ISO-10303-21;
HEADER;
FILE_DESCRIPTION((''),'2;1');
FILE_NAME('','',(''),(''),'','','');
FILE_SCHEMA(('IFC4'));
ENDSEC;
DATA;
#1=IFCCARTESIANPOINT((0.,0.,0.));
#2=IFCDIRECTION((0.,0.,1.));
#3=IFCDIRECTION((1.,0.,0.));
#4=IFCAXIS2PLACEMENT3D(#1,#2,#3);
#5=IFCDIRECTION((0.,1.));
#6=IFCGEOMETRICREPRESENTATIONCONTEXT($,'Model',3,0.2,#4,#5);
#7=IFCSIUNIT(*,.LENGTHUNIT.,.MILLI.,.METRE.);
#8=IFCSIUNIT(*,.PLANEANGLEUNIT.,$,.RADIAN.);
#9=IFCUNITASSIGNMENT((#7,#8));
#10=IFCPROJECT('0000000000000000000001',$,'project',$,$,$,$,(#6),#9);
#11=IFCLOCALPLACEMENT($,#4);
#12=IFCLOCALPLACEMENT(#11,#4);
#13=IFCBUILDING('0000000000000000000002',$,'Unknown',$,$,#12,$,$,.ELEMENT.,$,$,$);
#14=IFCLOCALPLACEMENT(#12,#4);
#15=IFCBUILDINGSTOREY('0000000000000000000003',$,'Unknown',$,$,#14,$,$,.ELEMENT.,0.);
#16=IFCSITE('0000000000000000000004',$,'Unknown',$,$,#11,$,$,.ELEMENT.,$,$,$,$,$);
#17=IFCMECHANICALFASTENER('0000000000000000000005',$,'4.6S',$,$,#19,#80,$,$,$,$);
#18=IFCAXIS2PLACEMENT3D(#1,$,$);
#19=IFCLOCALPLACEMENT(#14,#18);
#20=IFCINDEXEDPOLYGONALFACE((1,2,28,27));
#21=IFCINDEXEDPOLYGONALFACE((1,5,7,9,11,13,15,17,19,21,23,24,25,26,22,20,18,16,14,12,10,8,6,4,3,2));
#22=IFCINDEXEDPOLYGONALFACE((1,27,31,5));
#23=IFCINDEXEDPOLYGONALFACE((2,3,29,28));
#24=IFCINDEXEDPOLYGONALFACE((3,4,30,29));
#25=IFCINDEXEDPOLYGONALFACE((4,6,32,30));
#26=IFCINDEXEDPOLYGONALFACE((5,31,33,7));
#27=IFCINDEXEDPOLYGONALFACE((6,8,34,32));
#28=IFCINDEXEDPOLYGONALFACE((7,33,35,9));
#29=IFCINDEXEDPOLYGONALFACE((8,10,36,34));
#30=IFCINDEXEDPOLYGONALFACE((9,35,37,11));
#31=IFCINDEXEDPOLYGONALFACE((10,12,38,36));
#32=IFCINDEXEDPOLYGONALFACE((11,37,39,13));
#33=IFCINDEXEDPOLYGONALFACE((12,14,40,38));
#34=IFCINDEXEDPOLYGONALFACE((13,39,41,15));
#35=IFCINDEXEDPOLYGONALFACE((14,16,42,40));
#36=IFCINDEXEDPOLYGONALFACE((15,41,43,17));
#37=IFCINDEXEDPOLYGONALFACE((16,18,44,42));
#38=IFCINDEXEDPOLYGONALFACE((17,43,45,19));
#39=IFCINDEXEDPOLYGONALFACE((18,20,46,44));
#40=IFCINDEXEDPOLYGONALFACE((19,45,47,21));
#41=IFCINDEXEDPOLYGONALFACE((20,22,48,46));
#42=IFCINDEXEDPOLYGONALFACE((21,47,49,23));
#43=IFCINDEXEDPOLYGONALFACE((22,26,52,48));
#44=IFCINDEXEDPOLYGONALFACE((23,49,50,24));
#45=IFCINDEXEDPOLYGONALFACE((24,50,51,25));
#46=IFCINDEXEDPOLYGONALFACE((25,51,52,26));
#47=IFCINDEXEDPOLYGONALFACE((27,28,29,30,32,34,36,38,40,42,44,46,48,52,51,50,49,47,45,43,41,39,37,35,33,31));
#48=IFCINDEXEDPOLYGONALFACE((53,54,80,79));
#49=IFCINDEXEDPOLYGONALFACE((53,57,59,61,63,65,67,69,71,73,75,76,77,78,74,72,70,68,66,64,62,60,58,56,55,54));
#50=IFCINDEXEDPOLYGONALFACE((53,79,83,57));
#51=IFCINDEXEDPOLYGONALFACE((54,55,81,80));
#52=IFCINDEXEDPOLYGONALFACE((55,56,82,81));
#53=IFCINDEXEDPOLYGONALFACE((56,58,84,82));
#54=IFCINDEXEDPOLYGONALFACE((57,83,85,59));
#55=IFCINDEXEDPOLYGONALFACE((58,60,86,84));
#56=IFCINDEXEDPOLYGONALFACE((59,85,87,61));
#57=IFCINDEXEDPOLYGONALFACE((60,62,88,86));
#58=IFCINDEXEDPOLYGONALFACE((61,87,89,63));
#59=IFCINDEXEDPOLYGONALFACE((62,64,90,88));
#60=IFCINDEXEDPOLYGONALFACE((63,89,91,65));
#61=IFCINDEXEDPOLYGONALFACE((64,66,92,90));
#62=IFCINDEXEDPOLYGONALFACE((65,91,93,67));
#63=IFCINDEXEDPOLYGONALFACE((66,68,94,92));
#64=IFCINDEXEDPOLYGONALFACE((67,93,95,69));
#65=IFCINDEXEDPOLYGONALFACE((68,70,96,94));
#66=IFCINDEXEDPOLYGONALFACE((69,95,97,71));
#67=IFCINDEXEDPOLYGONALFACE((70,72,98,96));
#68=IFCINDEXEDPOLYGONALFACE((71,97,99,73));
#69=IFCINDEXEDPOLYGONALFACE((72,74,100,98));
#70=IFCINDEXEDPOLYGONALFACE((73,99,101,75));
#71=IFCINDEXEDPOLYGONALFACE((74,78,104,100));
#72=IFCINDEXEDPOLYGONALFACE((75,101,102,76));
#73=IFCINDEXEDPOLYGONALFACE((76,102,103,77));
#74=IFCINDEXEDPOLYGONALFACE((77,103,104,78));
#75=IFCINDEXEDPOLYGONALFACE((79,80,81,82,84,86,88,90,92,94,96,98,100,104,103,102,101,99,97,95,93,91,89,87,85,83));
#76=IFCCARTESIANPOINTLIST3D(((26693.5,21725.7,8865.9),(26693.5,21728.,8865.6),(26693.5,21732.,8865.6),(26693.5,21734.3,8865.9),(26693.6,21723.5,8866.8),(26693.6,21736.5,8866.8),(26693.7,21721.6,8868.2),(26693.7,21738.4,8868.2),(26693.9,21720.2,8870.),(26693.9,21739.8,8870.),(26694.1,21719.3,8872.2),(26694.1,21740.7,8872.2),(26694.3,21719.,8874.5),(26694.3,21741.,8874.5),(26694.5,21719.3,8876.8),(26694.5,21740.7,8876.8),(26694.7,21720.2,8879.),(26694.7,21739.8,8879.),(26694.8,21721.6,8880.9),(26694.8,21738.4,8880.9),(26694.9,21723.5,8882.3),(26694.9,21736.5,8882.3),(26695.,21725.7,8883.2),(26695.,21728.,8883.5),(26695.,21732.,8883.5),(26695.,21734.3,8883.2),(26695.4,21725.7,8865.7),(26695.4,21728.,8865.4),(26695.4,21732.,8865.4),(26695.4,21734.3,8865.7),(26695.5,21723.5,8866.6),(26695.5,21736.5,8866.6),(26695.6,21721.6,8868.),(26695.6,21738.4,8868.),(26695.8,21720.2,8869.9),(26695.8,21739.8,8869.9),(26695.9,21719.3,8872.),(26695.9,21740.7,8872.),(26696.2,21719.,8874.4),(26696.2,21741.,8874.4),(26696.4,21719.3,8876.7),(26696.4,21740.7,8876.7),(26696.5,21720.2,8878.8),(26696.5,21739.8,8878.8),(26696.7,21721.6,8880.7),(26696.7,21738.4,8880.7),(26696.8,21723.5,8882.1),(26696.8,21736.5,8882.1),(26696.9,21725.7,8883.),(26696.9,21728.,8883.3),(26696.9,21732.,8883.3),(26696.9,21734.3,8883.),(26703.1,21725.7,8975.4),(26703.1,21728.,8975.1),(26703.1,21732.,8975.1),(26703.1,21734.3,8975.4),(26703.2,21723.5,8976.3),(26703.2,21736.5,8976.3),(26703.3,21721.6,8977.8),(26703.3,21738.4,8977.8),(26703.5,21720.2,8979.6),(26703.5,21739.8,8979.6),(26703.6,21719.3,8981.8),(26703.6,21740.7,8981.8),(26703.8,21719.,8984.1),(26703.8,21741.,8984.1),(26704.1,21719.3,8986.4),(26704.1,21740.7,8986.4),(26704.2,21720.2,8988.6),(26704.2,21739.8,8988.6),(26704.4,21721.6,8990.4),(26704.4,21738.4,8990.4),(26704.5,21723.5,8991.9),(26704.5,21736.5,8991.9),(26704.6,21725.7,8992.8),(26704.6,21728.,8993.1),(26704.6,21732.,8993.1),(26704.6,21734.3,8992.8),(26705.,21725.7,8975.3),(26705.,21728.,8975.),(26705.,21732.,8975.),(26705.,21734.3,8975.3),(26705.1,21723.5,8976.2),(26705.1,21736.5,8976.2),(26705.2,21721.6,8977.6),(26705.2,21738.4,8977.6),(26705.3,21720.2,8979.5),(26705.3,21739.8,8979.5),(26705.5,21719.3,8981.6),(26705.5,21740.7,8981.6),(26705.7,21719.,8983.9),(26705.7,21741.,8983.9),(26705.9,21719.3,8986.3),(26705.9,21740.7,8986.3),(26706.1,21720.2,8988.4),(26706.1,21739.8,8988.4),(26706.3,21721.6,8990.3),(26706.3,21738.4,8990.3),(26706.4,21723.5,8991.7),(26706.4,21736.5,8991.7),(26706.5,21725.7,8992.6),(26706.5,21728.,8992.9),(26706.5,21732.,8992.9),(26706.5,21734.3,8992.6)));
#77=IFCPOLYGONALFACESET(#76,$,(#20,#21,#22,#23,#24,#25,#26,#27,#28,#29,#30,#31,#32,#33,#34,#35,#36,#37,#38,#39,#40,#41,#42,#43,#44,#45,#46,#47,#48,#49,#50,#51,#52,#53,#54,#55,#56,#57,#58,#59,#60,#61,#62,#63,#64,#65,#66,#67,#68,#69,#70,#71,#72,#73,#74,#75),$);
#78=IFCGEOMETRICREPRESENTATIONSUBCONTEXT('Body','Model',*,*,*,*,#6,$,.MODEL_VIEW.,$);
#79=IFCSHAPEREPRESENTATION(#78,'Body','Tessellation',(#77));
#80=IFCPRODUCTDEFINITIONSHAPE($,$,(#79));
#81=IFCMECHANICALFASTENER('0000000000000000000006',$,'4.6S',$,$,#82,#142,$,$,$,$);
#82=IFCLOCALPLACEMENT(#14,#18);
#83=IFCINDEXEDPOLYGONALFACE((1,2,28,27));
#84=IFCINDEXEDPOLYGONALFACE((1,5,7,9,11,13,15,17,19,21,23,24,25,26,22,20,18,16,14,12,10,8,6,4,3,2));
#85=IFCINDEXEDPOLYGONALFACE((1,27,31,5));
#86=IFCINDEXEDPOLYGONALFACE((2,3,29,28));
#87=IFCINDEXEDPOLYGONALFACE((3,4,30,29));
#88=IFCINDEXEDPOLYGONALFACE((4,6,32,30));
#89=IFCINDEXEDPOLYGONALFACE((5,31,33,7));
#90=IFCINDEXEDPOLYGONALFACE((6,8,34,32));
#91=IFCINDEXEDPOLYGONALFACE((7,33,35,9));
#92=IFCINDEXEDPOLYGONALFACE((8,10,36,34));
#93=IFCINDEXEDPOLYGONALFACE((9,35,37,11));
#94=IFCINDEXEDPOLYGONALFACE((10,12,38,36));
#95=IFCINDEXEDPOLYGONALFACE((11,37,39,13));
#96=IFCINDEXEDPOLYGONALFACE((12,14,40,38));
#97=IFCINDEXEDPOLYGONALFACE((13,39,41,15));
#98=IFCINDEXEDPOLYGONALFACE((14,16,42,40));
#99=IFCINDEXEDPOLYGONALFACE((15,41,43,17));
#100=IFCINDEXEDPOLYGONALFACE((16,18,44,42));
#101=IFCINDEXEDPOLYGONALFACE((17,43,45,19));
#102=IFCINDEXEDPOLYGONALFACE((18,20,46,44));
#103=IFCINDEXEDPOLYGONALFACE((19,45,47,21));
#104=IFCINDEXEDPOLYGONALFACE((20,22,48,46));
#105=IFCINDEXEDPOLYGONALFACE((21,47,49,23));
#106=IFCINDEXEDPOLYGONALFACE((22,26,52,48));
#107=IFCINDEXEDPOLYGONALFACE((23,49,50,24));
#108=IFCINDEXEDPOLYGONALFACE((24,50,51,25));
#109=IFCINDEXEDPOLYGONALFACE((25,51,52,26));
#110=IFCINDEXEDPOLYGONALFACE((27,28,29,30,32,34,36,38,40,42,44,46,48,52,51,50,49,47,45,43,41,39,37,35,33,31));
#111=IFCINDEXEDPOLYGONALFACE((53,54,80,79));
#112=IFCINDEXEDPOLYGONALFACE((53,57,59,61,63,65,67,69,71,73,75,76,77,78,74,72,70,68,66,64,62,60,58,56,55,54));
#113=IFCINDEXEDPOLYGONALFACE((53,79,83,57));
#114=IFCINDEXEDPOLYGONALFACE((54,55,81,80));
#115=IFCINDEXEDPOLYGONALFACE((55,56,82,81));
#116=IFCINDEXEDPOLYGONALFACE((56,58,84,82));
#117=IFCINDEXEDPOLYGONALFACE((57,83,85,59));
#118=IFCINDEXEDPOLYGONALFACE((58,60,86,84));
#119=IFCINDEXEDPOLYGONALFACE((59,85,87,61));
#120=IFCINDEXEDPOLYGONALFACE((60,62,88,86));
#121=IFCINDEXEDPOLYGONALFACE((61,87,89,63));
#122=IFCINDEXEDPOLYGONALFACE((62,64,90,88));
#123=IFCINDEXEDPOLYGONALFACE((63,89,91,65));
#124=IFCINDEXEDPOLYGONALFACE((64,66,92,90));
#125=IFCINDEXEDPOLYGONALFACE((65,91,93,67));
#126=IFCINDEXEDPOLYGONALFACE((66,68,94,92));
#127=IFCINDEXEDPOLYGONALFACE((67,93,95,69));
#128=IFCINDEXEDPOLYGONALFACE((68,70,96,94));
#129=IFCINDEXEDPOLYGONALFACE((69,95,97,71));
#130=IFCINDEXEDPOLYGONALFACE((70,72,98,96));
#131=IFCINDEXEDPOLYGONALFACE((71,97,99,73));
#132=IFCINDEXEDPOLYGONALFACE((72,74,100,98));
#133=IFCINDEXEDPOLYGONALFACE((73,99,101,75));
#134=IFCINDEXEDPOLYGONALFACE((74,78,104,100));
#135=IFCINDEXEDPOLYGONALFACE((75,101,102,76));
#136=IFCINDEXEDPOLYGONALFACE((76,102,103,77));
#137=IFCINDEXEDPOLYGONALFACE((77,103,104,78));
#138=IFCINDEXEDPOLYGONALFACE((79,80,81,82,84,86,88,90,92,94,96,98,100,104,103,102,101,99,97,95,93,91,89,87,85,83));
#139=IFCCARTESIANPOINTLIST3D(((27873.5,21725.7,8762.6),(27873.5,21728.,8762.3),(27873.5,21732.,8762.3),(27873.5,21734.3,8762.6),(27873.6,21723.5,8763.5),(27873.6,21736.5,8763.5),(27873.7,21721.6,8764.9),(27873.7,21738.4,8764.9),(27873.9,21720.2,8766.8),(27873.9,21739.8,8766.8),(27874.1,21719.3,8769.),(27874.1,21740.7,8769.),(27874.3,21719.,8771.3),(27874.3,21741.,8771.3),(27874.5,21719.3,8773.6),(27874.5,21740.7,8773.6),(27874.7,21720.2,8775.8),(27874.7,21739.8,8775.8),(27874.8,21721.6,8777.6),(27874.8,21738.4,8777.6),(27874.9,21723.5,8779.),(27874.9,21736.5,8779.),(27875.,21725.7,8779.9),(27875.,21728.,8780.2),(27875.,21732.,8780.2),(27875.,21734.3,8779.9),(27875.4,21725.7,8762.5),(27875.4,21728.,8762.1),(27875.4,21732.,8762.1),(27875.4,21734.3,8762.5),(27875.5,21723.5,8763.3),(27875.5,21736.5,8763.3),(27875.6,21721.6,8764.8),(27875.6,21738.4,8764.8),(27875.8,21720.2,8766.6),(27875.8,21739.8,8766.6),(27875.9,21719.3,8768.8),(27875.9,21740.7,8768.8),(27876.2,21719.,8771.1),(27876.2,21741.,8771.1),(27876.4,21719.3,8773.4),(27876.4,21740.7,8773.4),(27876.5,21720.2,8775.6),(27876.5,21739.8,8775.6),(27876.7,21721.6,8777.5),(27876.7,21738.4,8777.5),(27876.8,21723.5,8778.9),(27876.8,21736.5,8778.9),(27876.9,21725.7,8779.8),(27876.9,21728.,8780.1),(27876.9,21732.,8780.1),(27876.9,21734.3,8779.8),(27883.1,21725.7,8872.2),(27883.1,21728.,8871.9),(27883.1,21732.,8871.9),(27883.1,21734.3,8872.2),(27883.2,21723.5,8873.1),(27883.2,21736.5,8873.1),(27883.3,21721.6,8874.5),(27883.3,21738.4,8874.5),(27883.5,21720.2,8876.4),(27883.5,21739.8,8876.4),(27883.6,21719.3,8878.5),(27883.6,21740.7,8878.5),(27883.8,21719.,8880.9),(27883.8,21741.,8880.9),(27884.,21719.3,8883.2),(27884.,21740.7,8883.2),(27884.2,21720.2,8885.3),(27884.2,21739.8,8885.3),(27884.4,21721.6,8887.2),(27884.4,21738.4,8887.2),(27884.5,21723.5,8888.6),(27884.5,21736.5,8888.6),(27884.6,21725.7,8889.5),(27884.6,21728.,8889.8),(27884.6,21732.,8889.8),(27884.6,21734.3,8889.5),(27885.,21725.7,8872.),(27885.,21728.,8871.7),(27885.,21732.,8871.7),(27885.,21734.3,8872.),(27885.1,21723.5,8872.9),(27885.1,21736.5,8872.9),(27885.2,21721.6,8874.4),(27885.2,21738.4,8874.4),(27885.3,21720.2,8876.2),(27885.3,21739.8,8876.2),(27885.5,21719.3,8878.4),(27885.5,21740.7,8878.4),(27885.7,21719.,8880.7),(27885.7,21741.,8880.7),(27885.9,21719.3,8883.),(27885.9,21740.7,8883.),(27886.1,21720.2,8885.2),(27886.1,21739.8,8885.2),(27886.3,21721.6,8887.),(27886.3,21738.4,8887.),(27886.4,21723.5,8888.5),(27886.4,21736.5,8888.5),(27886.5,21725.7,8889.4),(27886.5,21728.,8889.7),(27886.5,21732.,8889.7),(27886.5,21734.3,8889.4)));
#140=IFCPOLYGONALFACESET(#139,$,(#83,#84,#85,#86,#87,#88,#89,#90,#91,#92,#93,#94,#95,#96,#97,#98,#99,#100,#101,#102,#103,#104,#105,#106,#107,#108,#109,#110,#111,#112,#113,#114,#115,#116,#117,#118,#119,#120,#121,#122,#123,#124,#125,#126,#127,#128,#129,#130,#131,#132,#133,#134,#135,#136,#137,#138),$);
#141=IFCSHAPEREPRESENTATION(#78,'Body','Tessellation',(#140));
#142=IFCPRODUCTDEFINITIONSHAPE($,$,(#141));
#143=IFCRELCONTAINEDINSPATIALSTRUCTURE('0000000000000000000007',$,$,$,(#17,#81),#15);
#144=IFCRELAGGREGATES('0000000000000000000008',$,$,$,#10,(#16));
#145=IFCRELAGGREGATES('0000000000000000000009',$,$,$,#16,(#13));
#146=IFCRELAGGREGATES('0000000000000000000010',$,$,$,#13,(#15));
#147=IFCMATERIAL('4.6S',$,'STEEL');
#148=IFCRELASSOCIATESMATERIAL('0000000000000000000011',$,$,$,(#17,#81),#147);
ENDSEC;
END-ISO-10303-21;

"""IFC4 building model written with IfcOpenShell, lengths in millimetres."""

from ifc_helpers import new_model, si_unit, direction, frame, origin_with_axes, place, context, subcontext, project, spatial, line, arc, indexed_curve, outline, extrude, source, transform, mapped, material, element, save


model = new_model("IFC4")

# Units and contexts
model_context = context("Model", 3, precision=0.2, world=origin_with_axes(), true_north=direction((0.0, 1.0)))
body_context = subcontext(model_context, "Body", "Model", "MODEL_VIEW")
ifc_project = project(units=[si_unit("LENGTHUNIT", "METRE", prefix="MILLI"), si_unit("PLANEANGLEUNIT", "RADIAN")], contexts=[model_context])

# Site, building, storey
site_placement = place(None, origin_with_axes())
site = spatial("IfcSite", under=ifc_project, at=site_placement, Name="Unknown", CompositionType="ELEMENT")
building_placement = place(site_placement, origin_with_axes())
building = spatial("IfcBuilding", under=site, at=building_placement, Name="Unknown", CompositionType="ELEMENT")
storey_placement = place(building_placement, origin_with_axes())
storey = spatial("IfcBuildingStorey", under=building, at=storey_placement, Name="Unknown", CompositionType="ELEMENT", Elevation=0.0)

# Mechanical fasteners
ifc_material_1 = material(Name="4.6S", Category="STEEL")
shared_shape_1 = source(origin_with_axes(), body_context, "Body", "SweptSolid", [
    extrude(outline(indexed_curve([(-2.0, 9.0), (2.0, 9.0), (2.0, 9.0), (8.4, 6.4), (11.0, 0.0), (8.4, -6.4), (2.0, -9.0), (-2.0, -9.0), (-2.8, -9.0), (-11.0, 0.0), (-8.4, 6.4)], segments=[line(1, 2, 3), arc(3, 4, 5), arc(5, 6, 7), line(7, 8), arc(8, 9, 10), arc(10, 11, 1)])), frame((0.0, 0.0, 0.9), z_axis=(0.0, 0.0, -1.0), x_axis=(0.0, 1.0, 0.0)), (0.0, 0.0, 1.0), 1.9),
])
mechanical_fastener_1_placement = place(storey_placement, frame((26695.2, 21730.0, 8874.4), z_axis=(-0.996194, 0.0, 0.08716), x_axis=(0.08716, 0.0, 0.996194)))
element("IfcMechanicalFastener", 1, at=mechanical_fastener_1_placement, inside=storey, material=ifc_material_1, Name="4.6S", context=body_context, shape_type="MappedRepresentation", body=[
    mapped(shared_shape_1, transform((0.0, 0.0, 0.0))),
    mapped(shared_shape_1, transform((110.0, 0.0, 0.0))),
])
shared_shape_2 = source(origin_with_axes(), body_context, "Body", "SweptSolid", [
    extrude(outline(indexed_curve([(-2.0, 9.0), (2.0, 9.0), (2.0, 9.0), (8.4, 6.4), (11.0, 0.0), (8.4, -6.4), (2.0, -9.0), (-2.0, -9.0), (-2.8, -9.0), (-11.0, 0.0), (-8.4, 6.4)], segments=[line(1, 2, 3), arc(3, 4, 5), arc(5, 6, 7), line(7, 8), arc(8, 9, 10), arc(10, 11, 1)])), frame((0.0, 0.0, 1.0), z_axis=(0.0, 0.0, -1.0), x_axis=(0.0, 1.0, 0.0)), (0.0, 0.0, 1.0), 1.9),
])
mechanical_fastener_2_placement = place(storey_placement, frame((27875.2, 21730.0, 8771.2), z_axis=(-0.996195, 0.0, 0.087148), x_axis=(0.087148, 0.0, 0.996195)))
element("IfcMechanicalFastener", 2, at=mechanical_fastener_2_placement, inside=storey, material=ifc_material_1, Name="4.6S", context=body_context, shape_type="MappedRepresentation", body=[
    mapped(shared_shape_2, transform((0.0, 0.0, 0.0))),
    mapped(shared_shape_2, transform((110.0, 0.0, 0.0))),
])

save(model, "model.ifc")
